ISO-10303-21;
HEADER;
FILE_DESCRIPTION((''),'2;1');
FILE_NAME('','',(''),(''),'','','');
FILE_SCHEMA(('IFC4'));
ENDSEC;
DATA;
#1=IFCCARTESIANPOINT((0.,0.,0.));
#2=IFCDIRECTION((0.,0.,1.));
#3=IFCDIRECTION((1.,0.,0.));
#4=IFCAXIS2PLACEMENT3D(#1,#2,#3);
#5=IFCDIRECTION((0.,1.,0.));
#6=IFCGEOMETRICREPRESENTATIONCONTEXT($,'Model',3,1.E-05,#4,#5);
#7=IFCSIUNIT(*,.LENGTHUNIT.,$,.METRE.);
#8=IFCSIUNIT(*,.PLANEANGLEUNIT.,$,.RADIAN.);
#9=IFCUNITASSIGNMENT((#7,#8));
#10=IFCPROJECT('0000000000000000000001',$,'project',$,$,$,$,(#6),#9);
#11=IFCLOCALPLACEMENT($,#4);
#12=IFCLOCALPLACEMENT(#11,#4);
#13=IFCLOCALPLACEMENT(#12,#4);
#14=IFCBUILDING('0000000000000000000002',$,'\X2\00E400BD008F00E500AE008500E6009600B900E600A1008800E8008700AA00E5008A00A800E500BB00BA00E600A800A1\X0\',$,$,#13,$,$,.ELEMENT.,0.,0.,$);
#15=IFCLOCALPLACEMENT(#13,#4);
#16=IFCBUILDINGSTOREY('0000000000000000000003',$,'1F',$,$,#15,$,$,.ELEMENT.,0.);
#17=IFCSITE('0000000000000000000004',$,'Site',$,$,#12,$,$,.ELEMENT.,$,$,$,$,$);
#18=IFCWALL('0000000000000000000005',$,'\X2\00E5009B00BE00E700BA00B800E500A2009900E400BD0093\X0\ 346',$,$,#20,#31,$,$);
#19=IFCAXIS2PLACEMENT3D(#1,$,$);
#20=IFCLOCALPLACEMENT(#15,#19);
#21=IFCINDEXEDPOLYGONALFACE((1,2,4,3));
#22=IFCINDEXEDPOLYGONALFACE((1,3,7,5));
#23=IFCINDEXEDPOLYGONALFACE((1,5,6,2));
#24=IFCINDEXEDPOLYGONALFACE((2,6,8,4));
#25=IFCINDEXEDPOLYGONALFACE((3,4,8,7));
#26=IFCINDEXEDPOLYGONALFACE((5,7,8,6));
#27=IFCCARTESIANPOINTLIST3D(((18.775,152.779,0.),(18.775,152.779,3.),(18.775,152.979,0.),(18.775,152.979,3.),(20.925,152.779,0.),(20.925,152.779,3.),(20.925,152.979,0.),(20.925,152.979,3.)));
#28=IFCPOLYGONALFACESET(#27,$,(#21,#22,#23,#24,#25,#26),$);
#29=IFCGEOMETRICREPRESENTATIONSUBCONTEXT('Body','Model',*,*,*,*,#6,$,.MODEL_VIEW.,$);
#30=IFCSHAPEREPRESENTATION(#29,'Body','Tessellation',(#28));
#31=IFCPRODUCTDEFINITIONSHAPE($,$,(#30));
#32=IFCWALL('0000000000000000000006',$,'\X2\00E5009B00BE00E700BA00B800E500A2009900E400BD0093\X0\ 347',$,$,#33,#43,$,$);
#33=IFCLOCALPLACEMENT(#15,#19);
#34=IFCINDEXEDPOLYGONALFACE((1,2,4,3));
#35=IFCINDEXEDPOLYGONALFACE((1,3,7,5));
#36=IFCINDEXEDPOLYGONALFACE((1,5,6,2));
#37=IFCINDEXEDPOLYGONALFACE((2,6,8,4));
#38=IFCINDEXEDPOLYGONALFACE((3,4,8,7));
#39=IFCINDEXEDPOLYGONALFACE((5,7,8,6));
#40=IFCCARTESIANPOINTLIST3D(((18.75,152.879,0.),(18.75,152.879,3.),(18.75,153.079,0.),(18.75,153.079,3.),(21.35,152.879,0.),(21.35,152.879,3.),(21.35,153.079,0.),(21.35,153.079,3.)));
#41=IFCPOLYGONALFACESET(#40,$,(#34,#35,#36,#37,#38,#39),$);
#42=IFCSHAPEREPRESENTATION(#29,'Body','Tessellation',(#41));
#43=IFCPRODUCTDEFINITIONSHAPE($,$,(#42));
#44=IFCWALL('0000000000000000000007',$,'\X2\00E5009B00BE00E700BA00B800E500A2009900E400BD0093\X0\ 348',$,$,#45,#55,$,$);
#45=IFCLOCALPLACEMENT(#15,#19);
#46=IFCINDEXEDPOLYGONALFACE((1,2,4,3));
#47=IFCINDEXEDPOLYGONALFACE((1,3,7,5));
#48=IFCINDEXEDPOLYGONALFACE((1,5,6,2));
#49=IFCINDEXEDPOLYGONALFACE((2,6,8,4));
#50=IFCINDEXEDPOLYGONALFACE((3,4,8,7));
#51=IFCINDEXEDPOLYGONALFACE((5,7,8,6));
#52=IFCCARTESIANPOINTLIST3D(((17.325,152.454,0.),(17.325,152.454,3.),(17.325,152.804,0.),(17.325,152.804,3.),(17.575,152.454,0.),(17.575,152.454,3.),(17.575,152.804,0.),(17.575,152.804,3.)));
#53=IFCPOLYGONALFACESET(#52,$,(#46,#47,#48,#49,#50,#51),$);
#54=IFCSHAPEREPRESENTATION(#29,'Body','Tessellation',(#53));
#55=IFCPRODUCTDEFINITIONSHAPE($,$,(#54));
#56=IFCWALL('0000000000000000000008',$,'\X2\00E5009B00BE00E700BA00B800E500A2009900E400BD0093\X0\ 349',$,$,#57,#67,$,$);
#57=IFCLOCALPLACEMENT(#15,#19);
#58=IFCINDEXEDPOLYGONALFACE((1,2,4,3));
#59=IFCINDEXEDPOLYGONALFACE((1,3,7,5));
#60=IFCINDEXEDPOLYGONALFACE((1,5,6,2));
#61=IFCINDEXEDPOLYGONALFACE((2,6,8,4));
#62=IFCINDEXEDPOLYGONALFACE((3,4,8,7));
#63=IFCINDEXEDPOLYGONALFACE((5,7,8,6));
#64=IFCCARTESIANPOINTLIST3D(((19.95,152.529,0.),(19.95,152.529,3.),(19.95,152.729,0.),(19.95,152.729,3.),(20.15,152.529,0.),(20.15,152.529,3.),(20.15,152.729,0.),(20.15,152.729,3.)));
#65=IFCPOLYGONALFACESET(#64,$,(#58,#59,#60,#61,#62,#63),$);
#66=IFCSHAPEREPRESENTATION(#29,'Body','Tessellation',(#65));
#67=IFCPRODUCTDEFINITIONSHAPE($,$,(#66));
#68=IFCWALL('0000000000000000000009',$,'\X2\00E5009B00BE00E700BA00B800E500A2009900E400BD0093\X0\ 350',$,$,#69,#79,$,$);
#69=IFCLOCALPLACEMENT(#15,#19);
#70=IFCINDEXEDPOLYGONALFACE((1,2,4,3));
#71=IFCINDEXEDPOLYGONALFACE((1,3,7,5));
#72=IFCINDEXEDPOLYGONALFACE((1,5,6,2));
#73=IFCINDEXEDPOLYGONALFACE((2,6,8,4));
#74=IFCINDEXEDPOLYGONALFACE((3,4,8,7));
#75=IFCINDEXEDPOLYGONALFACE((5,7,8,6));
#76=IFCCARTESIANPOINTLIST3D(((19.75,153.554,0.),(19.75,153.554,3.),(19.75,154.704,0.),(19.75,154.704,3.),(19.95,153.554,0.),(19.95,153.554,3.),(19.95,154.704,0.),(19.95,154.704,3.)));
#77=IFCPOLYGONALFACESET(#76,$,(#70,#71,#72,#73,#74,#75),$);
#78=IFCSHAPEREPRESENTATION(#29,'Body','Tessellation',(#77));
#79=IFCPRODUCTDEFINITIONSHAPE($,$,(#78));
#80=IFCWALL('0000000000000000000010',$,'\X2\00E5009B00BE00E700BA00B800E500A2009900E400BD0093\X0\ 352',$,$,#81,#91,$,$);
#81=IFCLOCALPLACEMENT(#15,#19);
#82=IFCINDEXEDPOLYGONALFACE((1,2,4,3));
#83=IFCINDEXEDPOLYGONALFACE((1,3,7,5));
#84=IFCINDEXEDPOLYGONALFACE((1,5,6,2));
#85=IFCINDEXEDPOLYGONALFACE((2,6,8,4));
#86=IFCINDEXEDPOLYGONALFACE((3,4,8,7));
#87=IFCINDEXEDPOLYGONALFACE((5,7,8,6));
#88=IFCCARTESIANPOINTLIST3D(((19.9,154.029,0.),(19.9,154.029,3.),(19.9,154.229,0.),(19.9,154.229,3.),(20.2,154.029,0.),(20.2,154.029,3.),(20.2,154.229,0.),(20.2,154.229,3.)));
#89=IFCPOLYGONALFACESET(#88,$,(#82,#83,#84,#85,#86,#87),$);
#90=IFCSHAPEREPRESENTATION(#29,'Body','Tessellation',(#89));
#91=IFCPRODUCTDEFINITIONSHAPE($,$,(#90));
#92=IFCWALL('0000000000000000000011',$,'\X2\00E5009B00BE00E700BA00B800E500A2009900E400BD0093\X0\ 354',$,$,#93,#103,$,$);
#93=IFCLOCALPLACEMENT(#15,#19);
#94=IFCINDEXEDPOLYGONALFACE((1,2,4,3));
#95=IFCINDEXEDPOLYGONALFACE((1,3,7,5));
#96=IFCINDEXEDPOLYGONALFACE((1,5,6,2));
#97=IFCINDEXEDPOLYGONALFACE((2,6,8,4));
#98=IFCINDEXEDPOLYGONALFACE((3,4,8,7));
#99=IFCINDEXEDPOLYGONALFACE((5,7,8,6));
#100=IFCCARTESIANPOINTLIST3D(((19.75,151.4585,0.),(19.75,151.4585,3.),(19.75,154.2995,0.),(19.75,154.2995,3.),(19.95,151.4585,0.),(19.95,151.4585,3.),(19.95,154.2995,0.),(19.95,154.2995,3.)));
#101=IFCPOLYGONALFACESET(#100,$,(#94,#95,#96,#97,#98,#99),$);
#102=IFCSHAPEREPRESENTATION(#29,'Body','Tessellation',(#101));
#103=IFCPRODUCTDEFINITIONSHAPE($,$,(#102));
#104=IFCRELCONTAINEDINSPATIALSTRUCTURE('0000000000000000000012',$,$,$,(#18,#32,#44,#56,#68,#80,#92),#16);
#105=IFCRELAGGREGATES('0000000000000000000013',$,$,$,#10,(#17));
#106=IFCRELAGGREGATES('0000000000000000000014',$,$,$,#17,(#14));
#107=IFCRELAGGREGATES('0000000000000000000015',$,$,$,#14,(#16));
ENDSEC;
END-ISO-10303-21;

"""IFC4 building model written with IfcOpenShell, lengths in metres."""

from ifc_helpers import new_model, si_unit, direction, frame, frame_2d, origin_with_axes, place, context, subcontext, project, spatial, rectangle, extrude, element, save


model = new_model("IFC4")

# Units and contexts
model_context = context("Model", 3, precision=1e-05, world=origin_with_axes(), true_north=direction((0.0, 1.0, 0.0)))
body_context = subcontext(model_context, "Body", "Model", "MODEL_VIEW")
ifc_project = project(units=[si_unit("LENGTHUNIT", "METRE"), si_unit("PLANEANGLEUNIT", "RADIAN")], contexts=[model_context])

# Site, building, storey
placement = place(None, origin_with_axes())
site_placement = place(placement, origin_with_axes())
site = spatial("IfcSite", under=ifc_project, at=site_placement, Name="Site", CompositionType="ELEMENT")
building_placement = place(site_placement, origin_with_axes())
building = spatial("IfcBuilding", under=site, at=building_placement, Name="ä½\u008få®\u0085æ\u0096¹æ¡\u0088è\u0087ªå\u008a¨å»ºæ¨¡", CompositionType="ELEMENT", ElevationOfRefHeight=0.0, ElevationOfTerrain=0.0)
storey_placement = place(building_placement, origin_with_axes())
storey = spatial("IfcBuildingStorey", under=building, at=storey_placement, Name="1F", CompositionType="ELEMENT", Elevation=0.0)

# Walls
wall_1_placement = place(storey_placement, frame((19.85, 152.879, 0.0), z_axis=(0.0, 0.0, 1.0), x_axis=(-1.0, 0.0, 0.0)))
element("IfcWall", 1, at=wall_1_placement, inside=storey, Name="å\u009b¾çº¸å¢\u0099ä½\u0093 346", context=body_context, shape_type="SweptSolid", body=[
    extrude(rectangle(XDim=2.15, YDim=0.2, at=frame_2d((0.0, 0.0), x_axis=(1.0, 0.0, 0.0))), frame((0.0, 0.0, 0.0), z_axis=(0.0, 0.0, 1.0)), (0.0, 0.0, 1.0), 3.0),
])
wall_2_placement = place(storey_placement, frame((20.05, 152.979, 0.0), z_axis=(0.0, 0.0, 1.0), x_axis=(-1.0, 0.0, 0.0)))
element("IfcWall", 2, at=wall_2_placement, inside=storey, Name="å\u009b¾çº¸å¢\u0099ä½\u0093 347", context=body_context, shape_type="SweptSolid", body=[
    extrude(rectangle(XDim=2.6, YDim=0.2, at=frame_2d((0.0, 0.0), x_axis=(1.0, 0.0, 0.0))), frame((0.0, 0.0, 0.0), z_axis=(0.0, 0.0, 1.0)), (0.0, 0.0, 1.0), 3.0),
])
wall_3_placement = place(storey_placement, frame((17.45, 152.629, 0.0), z_axis=(0.0, 0.0, 1.0), x_axis=(1.0, 0.0, 0.0)))
element("IfcWall", 3, at=wall_3_placement, inside=storey, Name="å\u009b¾çº¸å¢\u0099ä½\u0093 348", context=body_context, shape_type="SweptSolid", body=[
    extrude(rectangle(XDim=0.25, YDim=0.35, at=frame_2d((0.0, 0.0), x_axis=(1.0, 0.0, 0.0))), frame((0.0, 0.0, 0.0), z_axis=(0.0, 0.0, 1.0)), (0.0, 0.0, 1.0), 3.0),
])
wall_4_placement = place(storey_placement, frame((20.05, 152.629, 0.0), z_axis=(0.0, 0.0, 1.0), x_axis=(-1.0, 0.0, 0.0)))
element("IfcWall", 4, at=wall_4_placement, inside=storey, Name="å\u009b¾çº¸å¢\u0099ä½\u0093 349", context=body_context, shape_type="SweptSolid", body=[
    extrude(rectangle(XDim=0.2, YDim=0.2, at=frame_2d((0.0, 0.0), x_axis=(1.0, 0.0, 0.0))), frame((0.0, 0.0, 0.0), z_axis=(0.0, 0.0, 1.0)), (0.0, 0.0, 1.0), 3.0),
])
wall_5_placement = place(storey_placement, frame((19.85, 154.129, 0.0), z_axis=(0.0, 0.0, 1.0), x_axis=(0.0, -1.0, 0.0)))
element("IfcWall", 5, at=wall_5_placement, inside=storey, Name="å\u009b¾çº¸å¢\u0099ä½\u0093 350", context=body_context, shape_type="SweptSolid", body=[
    extrude(rectangle(XDim=1.15, YDim=0.2, at=frame_2d((0.0, 0.0), x_axis=(1.0, 0.0, 0.0))), frame((0.0, 0.0, 0.0), z_axis=(0.0, 0.0, 1.0)), (0.0, 0.0, 1.0), 3.0),
])
wall_6_placement = place(storey_placement, frame((20.05, 154.129, 0.0), z_axis=(0.0, 0.0, 1.0), x_axis=(-1.0, 0.0, 0.0)))
element("IfcWall", 6, at=wall_6_placement, inside=storey, Name="å\u009b¾çº¸å¢\u0099ä½\u0093 352", context=body_context, shape_type="SweptSolid", body=[
    extrude(rectangle(XDim=0.3, YDim=0.2, at=frame_2d((0.0, 0.0), x_axis=(1.0, 0.0, 0.0))), frame((0.0, 0.0, 0.0), z_axis=(0.0, 0.0, 1.0)), (0.0, 0.0, 1.0), 3.0),
])
wall_7_placement = place(storey_placement, frame((19.85, 152.879, 0.0), z_axis=(0.0, 0.0, 1.0), x_axis=(0.0, -1.0, 0.0)))
element("IfcWall", 7, at=wall_7_placement, inside=storey, Name="å\u009b¾çº¸å¢\u0099ä½\u0093 354", context=body_context, shape_type="SweptSolid", body=[
    extrude(rectangle(XDim=2.841, YDim=0.2, at=frame_2d((0.0, 0.0), x_axis=(1.0, 0.0, 0.0))), frame((0.0, 0.0, 0.0), z_axis=(0.0, 0.0, 1.0)), (0.0, 0.0, 1.0), 3.0),
])

save(model, "model.ifc")
